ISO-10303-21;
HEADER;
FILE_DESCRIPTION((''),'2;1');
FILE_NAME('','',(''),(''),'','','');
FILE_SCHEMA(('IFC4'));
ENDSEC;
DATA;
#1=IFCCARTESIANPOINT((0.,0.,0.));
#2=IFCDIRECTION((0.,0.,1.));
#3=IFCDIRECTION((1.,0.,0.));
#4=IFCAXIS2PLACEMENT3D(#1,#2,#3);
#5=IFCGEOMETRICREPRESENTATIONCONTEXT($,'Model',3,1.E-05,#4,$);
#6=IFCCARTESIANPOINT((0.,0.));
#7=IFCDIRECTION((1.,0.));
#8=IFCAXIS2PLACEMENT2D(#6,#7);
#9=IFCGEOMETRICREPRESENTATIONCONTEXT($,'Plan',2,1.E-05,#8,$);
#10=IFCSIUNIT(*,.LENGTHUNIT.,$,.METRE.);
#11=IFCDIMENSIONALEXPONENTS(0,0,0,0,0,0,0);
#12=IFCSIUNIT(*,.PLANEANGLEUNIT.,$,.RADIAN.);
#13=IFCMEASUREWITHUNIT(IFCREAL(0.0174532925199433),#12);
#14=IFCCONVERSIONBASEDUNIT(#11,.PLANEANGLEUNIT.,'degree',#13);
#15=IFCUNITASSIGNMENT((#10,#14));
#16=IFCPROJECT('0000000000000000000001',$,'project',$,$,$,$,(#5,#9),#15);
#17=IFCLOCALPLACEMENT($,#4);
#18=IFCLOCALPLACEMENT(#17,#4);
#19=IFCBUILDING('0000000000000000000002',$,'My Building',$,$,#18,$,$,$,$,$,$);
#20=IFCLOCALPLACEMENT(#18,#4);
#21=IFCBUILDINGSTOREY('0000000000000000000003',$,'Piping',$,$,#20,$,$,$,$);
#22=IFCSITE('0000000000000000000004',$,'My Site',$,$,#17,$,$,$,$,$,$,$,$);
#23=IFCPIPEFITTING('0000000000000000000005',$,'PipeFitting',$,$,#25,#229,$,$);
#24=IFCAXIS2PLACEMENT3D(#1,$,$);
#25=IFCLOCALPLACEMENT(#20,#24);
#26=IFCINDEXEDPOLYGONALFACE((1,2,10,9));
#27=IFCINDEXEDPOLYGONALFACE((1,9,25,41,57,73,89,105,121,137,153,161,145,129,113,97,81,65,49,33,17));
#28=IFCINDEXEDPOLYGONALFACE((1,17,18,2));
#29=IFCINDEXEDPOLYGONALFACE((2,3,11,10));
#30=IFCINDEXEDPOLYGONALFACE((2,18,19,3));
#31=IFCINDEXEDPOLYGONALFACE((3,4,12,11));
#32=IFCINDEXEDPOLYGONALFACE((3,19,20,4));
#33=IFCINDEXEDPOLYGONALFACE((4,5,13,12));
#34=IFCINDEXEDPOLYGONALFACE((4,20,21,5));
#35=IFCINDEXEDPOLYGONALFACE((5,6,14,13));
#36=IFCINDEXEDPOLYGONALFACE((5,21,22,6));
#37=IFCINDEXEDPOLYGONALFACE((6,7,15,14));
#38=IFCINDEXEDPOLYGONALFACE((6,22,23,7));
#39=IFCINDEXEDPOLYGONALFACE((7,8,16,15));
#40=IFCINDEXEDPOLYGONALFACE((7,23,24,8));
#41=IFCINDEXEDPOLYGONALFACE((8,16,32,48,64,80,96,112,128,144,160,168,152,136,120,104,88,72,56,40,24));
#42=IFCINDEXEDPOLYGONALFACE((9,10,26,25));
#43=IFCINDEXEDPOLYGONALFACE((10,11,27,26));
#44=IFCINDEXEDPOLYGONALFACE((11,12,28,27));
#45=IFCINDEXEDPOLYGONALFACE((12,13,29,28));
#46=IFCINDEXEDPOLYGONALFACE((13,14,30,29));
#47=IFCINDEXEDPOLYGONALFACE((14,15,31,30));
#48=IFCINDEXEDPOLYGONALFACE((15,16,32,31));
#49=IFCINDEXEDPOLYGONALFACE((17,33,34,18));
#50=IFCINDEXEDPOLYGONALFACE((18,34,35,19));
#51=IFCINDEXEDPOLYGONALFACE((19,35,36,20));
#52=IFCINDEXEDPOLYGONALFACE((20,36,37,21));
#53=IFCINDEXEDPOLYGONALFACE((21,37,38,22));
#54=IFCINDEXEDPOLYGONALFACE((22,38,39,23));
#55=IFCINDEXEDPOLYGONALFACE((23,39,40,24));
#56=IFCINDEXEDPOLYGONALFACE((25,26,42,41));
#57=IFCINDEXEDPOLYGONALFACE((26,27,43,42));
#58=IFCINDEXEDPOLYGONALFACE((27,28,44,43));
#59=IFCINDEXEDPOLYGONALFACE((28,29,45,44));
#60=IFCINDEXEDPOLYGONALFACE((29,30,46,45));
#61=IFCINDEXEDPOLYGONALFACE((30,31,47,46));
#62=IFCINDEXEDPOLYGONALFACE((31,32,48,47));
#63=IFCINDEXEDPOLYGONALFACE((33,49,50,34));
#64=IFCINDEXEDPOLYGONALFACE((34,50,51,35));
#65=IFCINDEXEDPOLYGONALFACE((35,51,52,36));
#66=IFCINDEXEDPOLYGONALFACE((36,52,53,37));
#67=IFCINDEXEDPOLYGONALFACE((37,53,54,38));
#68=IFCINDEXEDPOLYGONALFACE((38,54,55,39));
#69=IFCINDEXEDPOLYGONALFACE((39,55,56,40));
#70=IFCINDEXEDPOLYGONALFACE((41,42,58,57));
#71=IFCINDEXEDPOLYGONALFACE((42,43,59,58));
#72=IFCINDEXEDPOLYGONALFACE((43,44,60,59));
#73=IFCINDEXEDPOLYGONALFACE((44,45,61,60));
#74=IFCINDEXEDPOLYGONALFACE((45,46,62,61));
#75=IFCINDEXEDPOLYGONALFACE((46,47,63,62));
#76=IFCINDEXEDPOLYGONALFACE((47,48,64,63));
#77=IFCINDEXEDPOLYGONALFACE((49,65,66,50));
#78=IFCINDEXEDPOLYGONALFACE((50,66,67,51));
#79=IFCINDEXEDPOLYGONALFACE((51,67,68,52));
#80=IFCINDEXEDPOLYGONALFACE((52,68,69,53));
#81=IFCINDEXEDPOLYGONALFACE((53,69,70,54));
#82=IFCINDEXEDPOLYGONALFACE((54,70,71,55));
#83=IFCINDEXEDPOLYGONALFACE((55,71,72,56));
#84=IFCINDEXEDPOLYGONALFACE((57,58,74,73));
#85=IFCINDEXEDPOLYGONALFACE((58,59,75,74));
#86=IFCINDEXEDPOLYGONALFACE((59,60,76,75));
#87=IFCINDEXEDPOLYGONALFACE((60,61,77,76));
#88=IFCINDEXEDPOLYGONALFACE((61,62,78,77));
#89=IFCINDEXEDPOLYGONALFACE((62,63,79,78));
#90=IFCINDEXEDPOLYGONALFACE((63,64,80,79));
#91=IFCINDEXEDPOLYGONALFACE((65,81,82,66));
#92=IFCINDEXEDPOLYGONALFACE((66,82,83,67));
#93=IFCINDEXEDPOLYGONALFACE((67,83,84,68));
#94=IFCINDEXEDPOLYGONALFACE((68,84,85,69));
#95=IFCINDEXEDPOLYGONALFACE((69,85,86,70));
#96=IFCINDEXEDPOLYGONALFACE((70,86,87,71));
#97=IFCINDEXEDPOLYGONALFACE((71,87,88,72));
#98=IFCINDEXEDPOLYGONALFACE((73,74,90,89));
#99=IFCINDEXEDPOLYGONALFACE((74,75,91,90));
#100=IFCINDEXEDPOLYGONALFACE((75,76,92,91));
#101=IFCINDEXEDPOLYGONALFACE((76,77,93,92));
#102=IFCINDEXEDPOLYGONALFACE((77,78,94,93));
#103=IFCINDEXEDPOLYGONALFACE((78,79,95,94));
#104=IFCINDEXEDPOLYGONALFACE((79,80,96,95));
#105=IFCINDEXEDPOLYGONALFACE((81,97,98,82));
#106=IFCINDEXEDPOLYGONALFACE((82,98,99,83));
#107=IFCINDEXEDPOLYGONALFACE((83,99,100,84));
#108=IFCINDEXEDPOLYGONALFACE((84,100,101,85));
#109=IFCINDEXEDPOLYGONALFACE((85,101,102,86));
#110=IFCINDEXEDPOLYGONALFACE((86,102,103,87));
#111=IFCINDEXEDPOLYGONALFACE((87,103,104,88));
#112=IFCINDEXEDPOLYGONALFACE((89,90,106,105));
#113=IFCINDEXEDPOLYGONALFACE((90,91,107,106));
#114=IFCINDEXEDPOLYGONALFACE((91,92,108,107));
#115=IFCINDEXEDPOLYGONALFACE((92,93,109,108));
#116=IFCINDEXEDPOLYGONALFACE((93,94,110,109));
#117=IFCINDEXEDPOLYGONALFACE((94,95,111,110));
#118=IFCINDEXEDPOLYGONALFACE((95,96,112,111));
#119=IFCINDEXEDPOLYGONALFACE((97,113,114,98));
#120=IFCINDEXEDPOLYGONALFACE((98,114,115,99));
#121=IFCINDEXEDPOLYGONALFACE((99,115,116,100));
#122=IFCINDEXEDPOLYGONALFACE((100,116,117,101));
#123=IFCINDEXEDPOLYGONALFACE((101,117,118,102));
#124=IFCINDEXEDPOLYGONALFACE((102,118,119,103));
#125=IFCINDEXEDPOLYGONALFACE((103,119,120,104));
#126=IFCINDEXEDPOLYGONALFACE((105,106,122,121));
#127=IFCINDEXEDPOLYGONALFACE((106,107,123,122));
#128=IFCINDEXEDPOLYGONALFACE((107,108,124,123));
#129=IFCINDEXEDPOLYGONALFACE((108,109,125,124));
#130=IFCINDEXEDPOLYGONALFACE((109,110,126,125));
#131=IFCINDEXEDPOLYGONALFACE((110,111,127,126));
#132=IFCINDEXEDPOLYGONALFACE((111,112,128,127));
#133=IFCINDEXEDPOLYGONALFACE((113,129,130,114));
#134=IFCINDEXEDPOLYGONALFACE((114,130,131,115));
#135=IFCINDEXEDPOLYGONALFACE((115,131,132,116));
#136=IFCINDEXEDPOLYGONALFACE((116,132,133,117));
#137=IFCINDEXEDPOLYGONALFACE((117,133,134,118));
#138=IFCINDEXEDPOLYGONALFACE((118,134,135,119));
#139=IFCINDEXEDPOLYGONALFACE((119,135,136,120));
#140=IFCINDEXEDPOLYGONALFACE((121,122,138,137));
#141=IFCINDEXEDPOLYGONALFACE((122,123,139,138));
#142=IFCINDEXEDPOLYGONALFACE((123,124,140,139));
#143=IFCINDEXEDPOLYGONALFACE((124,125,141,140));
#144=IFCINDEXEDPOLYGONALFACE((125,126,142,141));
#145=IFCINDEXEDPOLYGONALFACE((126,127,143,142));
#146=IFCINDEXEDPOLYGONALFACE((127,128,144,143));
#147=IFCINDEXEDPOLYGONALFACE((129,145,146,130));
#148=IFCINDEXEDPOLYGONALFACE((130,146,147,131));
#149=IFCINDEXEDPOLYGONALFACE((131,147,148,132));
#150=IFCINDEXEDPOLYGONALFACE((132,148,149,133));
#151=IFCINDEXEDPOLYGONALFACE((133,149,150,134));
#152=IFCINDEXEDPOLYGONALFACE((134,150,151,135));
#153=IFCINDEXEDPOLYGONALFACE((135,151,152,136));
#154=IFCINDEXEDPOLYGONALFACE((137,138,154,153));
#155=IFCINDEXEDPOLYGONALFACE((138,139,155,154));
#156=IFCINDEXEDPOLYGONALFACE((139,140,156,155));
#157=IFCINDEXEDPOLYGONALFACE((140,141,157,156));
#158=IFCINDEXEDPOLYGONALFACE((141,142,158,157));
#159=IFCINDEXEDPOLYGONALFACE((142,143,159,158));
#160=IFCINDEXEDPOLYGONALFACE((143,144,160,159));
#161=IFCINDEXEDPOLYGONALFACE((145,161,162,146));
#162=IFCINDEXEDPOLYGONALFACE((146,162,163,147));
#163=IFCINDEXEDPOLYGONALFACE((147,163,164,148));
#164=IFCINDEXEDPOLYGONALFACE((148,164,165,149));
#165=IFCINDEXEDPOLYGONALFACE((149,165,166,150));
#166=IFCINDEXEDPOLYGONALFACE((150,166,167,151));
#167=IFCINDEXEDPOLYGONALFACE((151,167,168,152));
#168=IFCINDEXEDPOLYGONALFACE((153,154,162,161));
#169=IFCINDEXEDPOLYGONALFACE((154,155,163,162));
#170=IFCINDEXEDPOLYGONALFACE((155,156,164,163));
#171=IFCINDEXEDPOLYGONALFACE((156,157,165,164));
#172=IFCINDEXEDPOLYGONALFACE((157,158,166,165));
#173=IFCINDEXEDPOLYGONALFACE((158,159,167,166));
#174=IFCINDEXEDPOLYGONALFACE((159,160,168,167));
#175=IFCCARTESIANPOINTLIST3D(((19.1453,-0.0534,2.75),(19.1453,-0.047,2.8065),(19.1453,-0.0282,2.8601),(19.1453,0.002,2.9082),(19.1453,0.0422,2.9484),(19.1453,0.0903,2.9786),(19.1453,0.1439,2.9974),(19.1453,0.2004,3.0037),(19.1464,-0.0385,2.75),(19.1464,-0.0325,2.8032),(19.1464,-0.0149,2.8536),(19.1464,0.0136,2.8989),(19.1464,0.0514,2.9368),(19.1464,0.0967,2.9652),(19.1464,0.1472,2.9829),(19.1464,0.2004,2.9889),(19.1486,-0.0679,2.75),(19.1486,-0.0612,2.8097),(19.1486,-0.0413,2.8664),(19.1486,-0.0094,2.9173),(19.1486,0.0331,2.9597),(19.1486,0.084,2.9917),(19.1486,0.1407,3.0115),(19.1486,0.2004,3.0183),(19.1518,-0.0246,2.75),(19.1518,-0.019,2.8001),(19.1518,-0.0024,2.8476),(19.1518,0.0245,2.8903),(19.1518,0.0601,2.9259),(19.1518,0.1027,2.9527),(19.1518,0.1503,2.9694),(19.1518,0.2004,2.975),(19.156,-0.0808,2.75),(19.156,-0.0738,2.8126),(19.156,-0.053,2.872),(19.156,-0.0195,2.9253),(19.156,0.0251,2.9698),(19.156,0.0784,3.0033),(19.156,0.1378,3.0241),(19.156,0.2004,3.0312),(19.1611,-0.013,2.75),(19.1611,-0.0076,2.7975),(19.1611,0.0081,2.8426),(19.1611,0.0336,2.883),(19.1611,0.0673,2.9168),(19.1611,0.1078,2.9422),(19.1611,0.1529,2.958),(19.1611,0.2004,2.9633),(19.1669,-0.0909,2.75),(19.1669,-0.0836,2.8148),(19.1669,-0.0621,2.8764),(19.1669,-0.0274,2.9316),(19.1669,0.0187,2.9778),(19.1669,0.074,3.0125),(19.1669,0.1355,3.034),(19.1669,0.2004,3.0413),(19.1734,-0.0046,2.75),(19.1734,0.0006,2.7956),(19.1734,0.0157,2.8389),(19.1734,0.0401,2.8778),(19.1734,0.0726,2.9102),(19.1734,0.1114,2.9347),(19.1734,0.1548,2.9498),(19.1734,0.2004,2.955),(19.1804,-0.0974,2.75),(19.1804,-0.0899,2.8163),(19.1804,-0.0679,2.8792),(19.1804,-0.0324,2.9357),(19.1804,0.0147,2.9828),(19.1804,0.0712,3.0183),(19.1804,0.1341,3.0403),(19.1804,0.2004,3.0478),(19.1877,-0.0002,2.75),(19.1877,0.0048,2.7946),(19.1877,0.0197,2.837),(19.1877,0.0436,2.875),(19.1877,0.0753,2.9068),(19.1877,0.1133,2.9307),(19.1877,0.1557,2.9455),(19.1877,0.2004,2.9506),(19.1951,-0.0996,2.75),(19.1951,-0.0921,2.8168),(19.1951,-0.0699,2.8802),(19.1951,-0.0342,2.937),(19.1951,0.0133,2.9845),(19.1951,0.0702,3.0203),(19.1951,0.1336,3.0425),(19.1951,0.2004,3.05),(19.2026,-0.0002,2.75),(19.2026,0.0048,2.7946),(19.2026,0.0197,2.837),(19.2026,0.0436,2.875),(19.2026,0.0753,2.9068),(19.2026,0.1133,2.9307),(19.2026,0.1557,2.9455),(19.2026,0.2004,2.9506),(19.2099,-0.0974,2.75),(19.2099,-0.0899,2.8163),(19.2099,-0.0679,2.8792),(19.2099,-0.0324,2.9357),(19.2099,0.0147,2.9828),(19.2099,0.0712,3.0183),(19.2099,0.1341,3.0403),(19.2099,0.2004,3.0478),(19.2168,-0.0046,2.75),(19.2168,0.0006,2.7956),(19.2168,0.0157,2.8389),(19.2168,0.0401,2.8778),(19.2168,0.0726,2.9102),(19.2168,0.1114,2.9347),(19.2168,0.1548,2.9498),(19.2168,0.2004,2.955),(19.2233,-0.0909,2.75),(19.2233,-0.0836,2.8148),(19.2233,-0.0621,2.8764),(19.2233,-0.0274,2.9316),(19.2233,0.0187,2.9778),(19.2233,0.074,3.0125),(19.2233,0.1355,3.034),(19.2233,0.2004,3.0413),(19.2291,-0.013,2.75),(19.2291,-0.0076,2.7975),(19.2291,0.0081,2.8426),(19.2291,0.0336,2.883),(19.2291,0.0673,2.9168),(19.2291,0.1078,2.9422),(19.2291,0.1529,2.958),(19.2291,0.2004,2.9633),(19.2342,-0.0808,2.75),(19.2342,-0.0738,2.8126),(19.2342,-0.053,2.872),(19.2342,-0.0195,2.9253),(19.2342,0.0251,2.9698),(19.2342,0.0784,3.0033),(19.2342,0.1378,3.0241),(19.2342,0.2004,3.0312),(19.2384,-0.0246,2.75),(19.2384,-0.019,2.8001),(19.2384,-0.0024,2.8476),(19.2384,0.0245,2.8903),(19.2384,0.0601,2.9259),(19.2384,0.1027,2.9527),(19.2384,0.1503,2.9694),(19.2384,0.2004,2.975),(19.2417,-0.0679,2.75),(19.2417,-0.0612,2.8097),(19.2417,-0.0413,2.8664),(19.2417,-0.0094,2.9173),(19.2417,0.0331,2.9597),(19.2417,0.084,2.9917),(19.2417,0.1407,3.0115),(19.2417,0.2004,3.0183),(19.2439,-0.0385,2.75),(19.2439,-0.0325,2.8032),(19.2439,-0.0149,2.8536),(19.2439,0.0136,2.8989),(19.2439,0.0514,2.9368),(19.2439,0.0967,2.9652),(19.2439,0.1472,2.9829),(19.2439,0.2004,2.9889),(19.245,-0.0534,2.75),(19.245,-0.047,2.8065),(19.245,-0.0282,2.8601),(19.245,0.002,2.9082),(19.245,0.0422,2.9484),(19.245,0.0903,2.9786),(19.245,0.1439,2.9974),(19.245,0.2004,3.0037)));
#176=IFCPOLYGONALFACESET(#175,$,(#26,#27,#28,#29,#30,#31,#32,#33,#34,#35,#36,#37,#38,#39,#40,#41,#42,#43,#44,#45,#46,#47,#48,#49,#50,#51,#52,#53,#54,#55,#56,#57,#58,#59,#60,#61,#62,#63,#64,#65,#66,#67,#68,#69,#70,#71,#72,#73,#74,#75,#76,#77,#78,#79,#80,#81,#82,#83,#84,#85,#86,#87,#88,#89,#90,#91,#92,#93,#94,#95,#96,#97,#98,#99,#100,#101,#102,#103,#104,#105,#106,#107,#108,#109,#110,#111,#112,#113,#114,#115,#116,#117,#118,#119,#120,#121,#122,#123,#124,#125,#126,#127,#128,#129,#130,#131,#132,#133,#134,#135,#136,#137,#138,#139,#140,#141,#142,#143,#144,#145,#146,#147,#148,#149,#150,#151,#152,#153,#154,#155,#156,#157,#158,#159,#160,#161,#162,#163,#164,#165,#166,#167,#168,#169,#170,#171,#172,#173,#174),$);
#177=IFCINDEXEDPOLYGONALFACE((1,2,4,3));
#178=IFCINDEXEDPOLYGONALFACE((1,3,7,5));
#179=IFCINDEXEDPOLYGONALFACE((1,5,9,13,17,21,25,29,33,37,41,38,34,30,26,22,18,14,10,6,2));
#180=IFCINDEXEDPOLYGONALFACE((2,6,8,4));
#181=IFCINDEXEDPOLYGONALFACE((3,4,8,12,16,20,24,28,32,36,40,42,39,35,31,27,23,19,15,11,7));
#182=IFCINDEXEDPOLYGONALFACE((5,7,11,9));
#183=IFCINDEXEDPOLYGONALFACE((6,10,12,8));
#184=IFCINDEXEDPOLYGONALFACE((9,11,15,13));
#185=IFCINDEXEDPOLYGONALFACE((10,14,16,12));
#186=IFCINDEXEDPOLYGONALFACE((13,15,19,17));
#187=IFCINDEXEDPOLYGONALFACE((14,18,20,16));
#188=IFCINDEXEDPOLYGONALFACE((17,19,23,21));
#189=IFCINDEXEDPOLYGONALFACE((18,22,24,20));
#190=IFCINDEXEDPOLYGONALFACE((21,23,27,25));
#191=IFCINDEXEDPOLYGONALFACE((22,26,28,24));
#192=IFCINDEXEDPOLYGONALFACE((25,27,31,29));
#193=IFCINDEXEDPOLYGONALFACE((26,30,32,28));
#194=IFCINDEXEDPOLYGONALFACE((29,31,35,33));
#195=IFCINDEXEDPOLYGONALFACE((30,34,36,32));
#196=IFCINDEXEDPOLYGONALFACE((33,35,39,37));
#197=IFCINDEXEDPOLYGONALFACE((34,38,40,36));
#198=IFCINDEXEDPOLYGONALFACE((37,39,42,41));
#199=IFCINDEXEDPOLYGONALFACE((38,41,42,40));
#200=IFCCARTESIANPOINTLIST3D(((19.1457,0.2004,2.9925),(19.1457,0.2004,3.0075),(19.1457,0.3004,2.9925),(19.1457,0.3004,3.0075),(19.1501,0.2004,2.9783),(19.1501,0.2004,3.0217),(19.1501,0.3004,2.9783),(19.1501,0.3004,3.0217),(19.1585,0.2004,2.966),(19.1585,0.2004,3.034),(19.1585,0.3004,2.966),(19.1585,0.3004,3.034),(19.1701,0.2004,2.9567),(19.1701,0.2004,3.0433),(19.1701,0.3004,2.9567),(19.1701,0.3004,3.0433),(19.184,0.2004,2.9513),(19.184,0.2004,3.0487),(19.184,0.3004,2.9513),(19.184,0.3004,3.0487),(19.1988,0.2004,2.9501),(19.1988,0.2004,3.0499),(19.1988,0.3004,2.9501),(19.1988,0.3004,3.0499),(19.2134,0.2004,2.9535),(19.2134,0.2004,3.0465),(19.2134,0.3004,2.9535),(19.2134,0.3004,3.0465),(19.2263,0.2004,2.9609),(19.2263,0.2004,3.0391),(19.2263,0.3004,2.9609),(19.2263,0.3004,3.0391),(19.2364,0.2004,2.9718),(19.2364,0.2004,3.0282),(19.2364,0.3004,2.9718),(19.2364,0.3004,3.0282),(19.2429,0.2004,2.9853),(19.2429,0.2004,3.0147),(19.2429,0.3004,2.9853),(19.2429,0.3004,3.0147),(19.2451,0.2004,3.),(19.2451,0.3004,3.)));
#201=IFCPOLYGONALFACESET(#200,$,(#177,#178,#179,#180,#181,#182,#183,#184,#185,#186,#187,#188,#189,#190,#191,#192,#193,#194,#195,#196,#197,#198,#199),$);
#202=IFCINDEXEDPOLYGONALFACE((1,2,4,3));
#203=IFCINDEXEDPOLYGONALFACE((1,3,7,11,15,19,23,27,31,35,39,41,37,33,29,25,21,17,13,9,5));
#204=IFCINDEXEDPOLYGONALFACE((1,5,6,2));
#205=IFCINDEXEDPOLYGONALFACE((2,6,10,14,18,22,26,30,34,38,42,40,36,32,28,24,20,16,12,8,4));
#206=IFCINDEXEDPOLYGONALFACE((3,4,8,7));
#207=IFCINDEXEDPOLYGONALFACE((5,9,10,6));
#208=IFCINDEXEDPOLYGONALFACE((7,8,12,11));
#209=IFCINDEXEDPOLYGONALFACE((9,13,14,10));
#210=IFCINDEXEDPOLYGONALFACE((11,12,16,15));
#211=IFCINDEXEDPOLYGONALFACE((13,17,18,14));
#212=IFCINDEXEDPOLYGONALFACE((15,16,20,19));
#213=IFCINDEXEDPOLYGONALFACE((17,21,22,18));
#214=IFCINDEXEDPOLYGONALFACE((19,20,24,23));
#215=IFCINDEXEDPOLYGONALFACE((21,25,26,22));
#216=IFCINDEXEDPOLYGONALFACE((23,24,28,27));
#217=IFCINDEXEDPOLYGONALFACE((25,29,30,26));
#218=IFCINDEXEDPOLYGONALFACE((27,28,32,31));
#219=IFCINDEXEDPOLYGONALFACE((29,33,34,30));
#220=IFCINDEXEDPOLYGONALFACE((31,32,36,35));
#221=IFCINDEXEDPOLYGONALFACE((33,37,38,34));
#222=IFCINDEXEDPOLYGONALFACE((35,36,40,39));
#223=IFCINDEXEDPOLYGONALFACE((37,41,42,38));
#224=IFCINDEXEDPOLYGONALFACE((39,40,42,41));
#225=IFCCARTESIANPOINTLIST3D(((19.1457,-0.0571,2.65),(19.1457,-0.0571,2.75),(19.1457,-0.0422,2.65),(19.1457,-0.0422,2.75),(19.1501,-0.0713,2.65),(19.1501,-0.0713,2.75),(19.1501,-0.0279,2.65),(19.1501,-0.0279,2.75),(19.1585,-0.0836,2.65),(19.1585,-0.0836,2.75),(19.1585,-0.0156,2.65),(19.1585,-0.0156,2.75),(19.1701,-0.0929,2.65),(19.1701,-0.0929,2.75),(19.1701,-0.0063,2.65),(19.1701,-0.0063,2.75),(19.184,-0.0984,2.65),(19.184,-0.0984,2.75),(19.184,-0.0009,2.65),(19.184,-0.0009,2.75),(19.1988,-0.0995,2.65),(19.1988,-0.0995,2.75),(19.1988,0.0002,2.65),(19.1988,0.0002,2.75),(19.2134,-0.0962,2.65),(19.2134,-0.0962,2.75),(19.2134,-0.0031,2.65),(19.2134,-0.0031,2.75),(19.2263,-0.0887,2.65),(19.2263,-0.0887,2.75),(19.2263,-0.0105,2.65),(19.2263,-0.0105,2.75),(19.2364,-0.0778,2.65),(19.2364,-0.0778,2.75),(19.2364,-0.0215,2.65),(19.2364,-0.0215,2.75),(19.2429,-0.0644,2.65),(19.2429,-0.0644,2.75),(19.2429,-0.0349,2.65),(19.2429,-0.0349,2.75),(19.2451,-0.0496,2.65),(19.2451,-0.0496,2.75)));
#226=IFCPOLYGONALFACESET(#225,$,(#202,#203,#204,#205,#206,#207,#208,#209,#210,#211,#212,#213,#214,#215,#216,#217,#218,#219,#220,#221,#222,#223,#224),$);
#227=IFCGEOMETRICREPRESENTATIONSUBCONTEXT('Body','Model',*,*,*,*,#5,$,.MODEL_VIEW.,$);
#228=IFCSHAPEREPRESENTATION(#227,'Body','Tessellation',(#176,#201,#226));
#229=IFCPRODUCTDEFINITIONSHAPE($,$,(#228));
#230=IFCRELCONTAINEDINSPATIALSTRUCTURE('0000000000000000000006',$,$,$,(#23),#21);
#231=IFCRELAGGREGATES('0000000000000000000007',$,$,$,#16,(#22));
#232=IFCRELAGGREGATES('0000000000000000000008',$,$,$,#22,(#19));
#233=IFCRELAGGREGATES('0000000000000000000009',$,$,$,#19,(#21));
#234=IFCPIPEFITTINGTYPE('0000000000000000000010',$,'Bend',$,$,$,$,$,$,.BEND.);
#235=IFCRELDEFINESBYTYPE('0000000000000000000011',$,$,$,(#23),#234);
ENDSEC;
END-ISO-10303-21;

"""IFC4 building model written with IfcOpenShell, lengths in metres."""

from ifc_helpers import new_model, entity, si_unit, converted_unit, frame, origin_with_axes, origin_2d_with_axis, place, context, subcontext, project, spatial, circle, extrude, source, transform, mapped, type_object, type_shapes, element, save


model = new_model("IFC4")

# Units and contexts
model_context = context("Model", 3, precision=1e-05, world=origin_with_axes())
plan_context = context("Plan", 2, precision=1e-05, world=origin_2d_with_axis())
body_context = subcontext(model_context, "Body", "Model", "MODEL_VIEW")
ifc_project = project(units=[si_unit("LENGTHUNIT", "METRE"), converted_unit("PLANEANGLEUNIT", "degree", entity("IfcReal", 0.0174532925199433), si_unit("PLANEANGLEUNIT", "RADIAN"), dimensions=[0, 0, 0, 0, 0, 0, 0])], contexts=[model_context, plan_context])

# Site, building, storey
site_placement = place(None, origin_with_axes())
site = spatial("IfcSite", under=ifc_project, at=site_placement, Name="My Site")
building_placement = place(site_placement, origin_with_axes())
building = spatial("IfcBuilding", under=site, at=building_placement, Name="My Building")
storey_placement = place(building_placement, origin_with_axes())
storey = spatial("IfcBuildingStorey", under=building, at=storey_placement, Name="Piping")

# Pipe fitting
pipe_fitting_type = type_object("IfcPipeFittingType", Name="Bend", PredefinedType="BEND")
shared_shape = source(origin_with_axes(), body_context, "Body", "SolidModel", [
    entity("IfcSweptDiskSolid", entity("IfcIndexedPolyCurve", entity("IfcCartesianPointList3D", [[0.0, 0.0, -0.1], [0.0, 0.0732, -0.2768], [0.0, 0.25, -0.35]]), [entity("IfcArcIndex", [1, 2, 3])]), 0.05),
    extrude(circle(Radius=0.05), origin_with_axes(), (0.0, 0.0, -1.0), 0.1),
    extrude(circle(Radius=0.05), frame((0.0, 0.25, -0.35), z_axis=(0.0, 1.0, 0.0), x_axis=(1.0, 0.0, 0.0)), (0.0, 0.0, 1.0), 0.1),
])
type_shapes(pipe_fitting_type, [shared_shape])
for number, where, z_axis, x_axis, name in (
    (1, (19.1951, 0.3004, 3.0), (0.0, 1.0, 0.0), (1.0, 0.0, 0.0), "PipeFitting"),
):
    element("IfcPipeFitting", number, at=place(storey_placement, frame(where, z_axis=z_axis, x_axis=x_axis)), inside=storey, type_object=pipe_fitting_type, Name=name, context=body_context, shape_type="MappedRepresentation", body=[
        mapped(shared_shape, transform((0.0, 0.0, 0.0), x_axis=(1.0, 0.0, 0.0), y_axis=(0.0, 1.0, 0.0), z_axis=(0.0, 0.0, 1.0), scale=1.0)),
    ])

save(model, "model.ifc")
